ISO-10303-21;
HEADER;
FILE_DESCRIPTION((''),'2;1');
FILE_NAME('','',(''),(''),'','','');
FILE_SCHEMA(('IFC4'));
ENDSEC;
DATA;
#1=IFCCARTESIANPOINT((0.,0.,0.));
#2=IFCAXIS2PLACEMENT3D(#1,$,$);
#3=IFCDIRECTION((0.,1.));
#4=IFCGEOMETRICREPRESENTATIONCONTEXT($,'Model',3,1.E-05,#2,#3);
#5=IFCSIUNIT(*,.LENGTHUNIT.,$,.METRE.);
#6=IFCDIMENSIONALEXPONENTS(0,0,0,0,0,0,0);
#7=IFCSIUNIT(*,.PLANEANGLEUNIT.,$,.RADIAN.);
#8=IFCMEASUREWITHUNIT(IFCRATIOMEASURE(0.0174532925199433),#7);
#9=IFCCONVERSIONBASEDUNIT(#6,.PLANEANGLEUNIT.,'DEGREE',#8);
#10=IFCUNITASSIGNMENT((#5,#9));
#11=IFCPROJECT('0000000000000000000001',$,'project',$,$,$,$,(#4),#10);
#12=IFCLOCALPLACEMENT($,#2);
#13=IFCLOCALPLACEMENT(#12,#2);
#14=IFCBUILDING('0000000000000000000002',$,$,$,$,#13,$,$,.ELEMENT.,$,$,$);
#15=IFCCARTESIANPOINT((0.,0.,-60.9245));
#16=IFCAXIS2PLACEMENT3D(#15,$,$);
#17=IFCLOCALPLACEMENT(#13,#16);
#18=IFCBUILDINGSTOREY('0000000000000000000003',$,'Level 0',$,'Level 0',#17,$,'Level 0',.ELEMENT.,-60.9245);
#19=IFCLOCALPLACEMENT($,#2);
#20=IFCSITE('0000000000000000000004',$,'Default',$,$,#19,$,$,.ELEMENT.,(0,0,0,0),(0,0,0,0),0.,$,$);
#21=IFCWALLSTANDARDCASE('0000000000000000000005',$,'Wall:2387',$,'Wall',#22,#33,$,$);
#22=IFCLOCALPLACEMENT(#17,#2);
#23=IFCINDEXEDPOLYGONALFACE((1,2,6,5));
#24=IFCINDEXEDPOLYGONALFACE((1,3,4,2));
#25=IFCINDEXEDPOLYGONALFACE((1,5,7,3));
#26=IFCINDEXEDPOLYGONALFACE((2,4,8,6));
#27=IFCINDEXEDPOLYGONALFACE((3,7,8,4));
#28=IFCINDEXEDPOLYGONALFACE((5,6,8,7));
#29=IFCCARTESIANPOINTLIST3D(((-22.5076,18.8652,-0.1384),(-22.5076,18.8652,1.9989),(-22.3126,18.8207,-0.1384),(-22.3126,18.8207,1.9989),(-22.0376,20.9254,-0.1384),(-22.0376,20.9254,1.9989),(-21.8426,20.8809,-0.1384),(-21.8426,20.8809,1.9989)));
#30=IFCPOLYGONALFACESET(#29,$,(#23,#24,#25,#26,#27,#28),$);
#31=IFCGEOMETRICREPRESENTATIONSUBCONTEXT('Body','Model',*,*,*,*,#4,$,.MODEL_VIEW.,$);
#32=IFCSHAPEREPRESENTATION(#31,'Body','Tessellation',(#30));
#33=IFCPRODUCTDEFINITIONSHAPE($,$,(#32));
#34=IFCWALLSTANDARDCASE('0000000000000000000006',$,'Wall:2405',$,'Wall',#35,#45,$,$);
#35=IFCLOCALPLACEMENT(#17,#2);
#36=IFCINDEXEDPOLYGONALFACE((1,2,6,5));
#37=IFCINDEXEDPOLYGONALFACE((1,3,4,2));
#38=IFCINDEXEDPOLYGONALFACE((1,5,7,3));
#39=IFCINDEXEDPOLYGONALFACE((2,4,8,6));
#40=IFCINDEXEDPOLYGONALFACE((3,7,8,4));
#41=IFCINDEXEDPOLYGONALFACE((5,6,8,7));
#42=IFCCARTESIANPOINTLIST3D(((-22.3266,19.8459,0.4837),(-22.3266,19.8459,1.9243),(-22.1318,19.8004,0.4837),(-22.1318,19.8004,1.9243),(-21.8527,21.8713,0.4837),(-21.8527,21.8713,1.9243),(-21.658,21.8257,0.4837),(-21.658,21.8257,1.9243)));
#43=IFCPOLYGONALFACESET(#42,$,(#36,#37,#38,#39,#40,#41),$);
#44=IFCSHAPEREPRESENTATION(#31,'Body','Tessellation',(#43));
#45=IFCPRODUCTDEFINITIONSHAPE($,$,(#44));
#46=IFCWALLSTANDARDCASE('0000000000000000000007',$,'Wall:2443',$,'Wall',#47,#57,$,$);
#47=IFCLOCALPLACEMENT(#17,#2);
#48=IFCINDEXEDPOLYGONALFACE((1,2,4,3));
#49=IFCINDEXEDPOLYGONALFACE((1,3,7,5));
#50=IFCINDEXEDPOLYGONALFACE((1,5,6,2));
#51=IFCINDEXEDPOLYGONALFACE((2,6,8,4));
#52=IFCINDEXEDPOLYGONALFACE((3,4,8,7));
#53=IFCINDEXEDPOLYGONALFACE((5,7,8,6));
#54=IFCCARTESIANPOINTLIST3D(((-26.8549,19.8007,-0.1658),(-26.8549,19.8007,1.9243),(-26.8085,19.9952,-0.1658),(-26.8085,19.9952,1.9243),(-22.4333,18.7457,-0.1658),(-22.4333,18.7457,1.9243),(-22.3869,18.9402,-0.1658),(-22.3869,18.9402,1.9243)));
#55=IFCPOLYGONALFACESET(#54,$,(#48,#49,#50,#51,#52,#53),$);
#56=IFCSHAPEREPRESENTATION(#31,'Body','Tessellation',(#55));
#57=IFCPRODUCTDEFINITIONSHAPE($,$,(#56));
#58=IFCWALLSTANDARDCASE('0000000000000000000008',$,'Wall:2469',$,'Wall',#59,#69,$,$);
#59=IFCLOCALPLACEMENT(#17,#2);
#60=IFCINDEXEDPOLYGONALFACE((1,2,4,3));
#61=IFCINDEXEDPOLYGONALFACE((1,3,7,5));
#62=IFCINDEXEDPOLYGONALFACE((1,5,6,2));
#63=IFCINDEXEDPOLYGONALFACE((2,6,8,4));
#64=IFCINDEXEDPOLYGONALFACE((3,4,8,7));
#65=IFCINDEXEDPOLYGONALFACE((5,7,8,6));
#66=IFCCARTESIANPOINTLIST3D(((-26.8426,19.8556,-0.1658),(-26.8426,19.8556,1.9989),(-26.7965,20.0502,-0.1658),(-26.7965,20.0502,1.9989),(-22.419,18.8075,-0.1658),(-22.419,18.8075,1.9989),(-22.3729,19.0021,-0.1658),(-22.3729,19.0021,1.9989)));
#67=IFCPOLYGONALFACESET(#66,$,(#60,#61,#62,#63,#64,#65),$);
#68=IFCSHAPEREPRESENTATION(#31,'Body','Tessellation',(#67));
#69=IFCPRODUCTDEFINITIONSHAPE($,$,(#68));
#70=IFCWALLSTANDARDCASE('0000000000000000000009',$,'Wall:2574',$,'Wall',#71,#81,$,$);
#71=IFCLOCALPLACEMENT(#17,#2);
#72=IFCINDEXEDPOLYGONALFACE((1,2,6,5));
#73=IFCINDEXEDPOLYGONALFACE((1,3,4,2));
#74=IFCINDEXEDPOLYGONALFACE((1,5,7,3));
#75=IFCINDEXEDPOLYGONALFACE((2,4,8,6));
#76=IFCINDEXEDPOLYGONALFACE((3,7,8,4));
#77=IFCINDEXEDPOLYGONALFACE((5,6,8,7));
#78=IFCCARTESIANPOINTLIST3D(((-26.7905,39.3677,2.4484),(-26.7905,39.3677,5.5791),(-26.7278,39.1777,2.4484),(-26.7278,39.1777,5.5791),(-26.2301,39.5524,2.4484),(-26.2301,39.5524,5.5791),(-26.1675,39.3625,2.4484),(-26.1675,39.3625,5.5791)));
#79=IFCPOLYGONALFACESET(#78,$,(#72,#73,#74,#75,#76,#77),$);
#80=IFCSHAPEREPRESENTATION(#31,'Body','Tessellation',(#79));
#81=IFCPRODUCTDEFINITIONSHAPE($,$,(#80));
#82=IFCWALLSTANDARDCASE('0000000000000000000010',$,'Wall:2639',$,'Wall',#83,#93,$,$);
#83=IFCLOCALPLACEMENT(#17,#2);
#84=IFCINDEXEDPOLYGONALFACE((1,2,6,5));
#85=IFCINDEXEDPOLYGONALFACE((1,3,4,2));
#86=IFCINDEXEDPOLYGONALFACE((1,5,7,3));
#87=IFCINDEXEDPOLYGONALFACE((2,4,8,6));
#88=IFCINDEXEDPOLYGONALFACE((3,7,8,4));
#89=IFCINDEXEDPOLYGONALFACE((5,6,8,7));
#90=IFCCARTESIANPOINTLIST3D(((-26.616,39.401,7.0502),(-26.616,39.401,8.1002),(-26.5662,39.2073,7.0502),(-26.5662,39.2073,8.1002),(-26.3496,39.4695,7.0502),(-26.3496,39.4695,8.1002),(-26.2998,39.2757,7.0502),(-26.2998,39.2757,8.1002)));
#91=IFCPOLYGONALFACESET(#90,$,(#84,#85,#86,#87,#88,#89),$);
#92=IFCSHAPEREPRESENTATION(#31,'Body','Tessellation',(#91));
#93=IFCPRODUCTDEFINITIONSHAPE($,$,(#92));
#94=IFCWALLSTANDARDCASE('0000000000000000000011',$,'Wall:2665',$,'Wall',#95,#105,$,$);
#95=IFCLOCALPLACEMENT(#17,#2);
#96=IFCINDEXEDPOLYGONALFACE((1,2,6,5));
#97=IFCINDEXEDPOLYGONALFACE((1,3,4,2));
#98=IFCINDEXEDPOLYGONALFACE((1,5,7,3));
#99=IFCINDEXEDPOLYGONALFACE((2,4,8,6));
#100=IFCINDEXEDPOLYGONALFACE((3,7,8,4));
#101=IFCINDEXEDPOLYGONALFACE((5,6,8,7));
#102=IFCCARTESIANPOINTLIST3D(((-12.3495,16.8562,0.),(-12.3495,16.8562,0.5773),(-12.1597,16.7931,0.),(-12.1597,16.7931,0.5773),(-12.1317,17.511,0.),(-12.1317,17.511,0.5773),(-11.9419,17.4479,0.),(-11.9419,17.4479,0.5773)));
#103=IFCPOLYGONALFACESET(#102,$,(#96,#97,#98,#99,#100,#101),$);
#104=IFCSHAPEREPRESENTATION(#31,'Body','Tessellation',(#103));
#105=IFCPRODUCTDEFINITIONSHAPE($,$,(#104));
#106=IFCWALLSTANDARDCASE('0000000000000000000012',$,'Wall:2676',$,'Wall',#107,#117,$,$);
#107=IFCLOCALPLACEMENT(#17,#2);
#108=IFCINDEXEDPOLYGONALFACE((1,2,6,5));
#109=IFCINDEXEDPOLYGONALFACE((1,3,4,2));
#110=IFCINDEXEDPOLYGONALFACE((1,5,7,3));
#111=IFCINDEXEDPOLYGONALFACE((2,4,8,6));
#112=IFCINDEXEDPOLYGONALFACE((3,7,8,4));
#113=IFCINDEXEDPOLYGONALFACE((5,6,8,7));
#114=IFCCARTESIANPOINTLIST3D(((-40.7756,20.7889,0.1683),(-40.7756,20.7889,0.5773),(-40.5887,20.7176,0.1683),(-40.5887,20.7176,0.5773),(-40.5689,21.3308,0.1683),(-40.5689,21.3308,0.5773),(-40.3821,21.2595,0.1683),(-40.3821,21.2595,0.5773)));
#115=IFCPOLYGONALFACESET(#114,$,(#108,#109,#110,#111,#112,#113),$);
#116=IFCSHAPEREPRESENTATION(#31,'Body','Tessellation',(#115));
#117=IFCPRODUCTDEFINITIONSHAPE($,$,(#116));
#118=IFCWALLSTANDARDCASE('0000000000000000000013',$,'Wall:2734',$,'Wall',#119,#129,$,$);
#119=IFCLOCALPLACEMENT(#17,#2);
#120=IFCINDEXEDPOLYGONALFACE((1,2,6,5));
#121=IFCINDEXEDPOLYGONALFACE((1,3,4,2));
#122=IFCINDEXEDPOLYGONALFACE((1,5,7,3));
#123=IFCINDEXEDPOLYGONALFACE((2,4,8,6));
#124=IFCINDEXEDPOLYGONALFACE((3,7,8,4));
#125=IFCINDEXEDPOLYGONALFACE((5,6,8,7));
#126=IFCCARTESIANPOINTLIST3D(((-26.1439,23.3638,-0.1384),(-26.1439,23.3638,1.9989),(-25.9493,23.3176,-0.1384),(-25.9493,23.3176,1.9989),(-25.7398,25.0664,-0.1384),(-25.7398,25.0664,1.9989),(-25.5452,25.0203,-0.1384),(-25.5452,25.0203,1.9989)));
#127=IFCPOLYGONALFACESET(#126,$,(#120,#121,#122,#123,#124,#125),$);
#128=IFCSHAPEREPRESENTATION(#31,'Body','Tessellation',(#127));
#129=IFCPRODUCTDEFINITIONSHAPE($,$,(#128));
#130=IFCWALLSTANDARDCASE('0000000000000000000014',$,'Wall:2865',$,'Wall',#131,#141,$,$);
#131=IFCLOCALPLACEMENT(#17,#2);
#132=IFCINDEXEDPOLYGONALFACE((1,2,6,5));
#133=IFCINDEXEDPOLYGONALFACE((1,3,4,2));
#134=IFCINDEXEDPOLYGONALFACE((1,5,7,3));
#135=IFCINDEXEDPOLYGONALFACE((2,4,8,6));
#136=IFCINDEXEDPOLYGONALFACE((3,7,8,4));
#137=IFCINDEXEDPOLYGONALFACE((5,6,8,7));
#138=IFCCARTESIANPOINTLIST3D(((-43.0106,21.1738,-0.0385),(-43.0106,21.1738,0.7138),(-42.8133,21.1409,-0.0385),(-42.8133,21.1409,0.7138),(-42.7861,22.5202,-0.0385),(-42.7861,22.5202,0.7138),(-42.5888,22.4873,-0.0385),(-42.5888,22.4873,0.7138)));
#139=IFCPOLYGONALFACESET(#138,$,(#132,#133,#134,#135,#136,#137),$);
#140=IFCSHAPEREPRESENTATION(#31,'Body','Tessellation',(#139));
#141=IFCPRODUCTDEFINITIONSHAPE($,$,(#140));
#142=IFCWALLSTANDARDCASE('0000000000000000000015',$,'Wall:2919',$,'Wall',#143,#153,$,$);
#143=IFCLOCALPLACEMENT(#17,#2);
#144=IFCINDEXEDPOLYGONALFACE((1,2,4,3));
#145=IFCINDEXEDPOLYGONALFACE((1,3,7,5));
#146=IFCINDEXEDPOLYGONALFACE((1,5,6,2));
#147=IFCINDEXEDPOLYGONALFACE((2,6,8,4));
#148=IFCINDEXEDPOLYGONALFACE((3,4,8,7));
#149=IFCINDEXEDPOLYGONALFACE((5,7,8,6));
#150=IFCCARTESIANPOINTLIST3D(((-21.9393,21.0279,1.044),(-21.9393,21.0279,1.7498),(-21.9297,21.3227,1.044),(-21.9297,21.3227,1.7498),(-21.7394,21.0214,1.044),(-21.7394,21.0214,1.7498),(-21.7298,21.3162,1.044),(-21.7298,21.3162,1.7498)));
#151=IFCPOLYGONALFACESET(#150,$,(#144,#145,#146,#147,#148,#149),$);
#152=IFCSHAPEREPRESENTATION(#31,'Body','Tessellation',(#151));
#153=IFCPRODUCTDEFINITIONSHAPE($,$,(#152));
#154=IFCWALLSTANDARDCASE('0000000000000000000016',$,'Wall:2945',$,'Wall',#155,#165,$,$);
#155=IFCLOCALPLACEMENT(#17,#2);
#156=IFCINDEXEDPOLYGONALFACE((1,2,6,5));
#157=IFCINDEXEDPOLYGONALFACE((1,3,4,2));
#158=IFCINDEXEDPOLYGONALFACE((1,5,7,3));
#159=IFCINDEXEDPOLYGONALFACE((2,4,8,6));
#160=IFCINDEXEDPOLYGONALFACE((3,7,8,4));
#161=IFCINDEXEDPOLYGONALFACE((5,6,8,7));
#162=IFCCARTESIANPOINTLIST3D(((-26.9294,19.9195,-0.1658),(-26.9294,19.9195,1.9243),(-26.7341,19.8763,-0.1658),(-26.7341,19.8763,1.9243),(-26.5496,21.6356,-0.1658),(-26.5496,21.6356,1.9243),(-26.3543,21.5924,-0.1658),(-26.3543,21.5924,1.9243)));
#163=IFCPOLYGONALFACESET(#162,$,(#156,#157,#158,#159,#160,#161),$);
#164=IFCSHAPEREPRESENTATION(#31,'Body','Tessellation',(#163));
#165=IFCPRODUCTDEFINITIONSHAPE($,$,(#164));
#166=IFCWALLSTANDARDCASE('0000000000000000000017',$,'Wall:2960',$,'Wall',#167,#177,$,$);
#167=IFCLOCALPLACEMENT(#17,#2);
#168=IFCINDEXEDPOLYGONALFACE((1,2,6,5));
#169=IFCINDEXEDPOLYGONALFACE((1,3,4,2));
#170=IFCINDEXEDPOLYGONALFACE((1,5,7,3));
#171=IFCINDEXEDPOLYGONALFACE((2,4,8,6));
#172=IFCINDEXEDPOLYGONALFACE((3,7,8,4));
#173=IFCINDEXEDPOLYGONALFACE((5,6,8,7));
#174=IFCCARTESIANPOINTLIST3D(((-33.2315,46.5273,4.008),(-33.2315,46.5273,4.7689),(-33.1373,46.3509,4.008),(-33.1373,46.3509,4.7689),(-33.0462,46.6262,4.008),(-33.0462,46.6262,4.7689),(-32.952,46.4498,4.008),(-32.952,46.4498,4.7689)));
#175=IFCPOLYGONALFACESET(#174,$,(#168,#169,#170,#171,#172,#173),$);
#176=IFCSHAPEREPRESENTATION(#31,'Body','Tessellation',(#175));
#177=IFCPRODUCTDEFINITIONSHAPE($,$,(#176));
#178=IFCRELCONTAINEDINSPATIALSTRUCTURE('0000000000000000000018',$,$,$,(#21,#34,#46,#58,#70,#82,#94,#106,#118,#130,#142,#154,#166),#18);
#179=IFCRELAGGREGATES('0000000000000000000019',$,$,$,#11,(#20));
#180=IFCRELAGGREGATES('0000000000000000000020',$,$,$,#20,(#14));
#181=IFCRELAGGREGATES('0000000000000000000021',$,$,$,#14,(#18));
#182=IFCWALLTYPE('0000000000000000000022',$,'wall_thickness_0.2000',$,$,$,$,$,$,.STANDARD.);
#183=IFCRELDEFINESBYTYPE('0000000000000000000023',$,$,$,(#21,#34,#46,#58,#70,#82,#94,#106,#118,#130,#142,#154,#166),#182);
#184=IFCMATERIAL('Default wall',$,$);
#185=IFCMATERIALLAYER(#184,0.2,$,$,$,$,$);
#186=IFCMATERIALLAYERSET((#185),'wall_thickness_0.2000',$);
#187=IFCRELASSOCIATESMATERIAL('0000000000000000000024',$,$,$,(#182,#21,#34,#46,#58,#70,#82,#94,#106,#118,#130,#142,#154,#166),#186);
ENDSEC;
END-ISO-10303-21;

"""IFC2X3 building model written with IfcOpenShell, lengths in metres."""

from ifc_helpers import new_model, entity, si_unit, converted_unit, direction, frame, origin, place, context, subcontext, project, spatial, polyline, outline, extrude, material, layer, layer_set, layer_usage, type_object, element, save


model = new_model("IFC2X3")

# Units and contexts
model_context = context("Model", 3, precision=1e-05, world=origin(), true_north=direction((0.0, 1.0)))
body_context = subcontext(model_context, "Body", "Model", "MODEL_VIEW")
ifc_project = project(units=[si_unit("LENGTHUNIT", "METRE"), converted_unit("PLANEANGLEUNIT", "DEGREE", entity("IfcRatioMeasure", 0.0174532925199433), si_unit("PLANEANGLEUNIT", "RADIAN"), dimensions=[0, 0, 0, 0, 0, 0, 0])], contexts=[model_context])

# Site, building, storey
site_placement = place(None, origin())
site = spatial("IfcSite", under=ifc_project, at=site_placement, Name="Default", CompositionType="ELEMENT", RefLatitude=(0, 0, 0, 0), RefLongitude=(0, 0, 0, 0), RefElevation=0.0)
placement_1 = place(None, origin())
building_placement = place(placement_1, origin())
building = spatial("IfcBuilding", under=site, at=building_placement, CompositionType="ELEMENT")
storey_placement = place(building_placement, frame((0.0, 0.0, -60.9245)))
storey = spatial("IfcBuildingStorey", under=building, at=storey_placement, Name="Level 0", ObjectType="Level 0", LongName="Level 0", CompositionType="ELEMENT", Elevation=-60.9245)

# Walls
ifc_material = material(Name="Default wall")
ifc_layer = layer(ifc_material, 0.2)
ifc_layer_set = layer_set([ifc_layer], Name="wall_thickness_0.2000")
ifc_layer_usage = layer_usage(ifc_layer_set, "AXIS2", "POSITIVE", -0.1)
wall_type = type_object("IfcWallType", Name="wall_thickness_0.2000", PredefinedType="STANDARD", material=ifc_layer_set)
placement_2 = place(building_placement, frame((0.0, 0.0, -61.0629)))
wall_1_placement = place(placement_2, frame((-21.9401, 20.9032, 0.0), z_axis=(0.0, 0.0, 1.0), x_axis=(-0.222418, -0.974951, 0.0)))
element("IfcWallStandardCase", 1, at=wall_1_placement, inside=storey, type_object=wall_type, material=ifc_layer_usage, Name="Wall:2387", ObjectType="Wall", context=body_context, shape_type="SweptSolid", body=[
    extrude(outline(polyline([(2.1132, -0.1), (2.1132, 0.1), (0.0, 0.1), (0.0, -0.1), (2.1132, -0.1)])), origin(), (0.0, 0.0, 1.0), 2.1372),
])
placement_3 = place(building_placement, frame((0.0, 0.0, -60.4408)))
wall_2_placement = place(placement_3, frame((-21.7553, 21.8485, 0.0), z_axis=(0.0, 0.0, 1.0), x_axis=(-0.227822, -0.973703, 0.0)))
element("IfcWallStandardCase", 2, at=wall_2_placement, inside=storey, type_object=wall_type, material=ifc_layer_usage, Name="Wall:2405", ObjectType="Wall", context=body_context, shape_type="SweptSolid", body=[
    extrude(outline(polyline([(2.08, -0.1), (2.08, 0.1), (0.0, 0.1), (0.0, -0.1), (2.08, -0.1)])), origin(), (0.0, 0.0, 1.0), 1.4406),
])
placement_4 = place(building_placement, frame((0.0, 0.0, -61.0903)))
wall_3_placement = place(placement_4, frame((-26.8317, 19.8979, 0.0), z_axis=(0.0, 0.0, 1.0), x_axis=(0.972696, -0.232084, 0.0)))
element("IfcWallStandardCase", 3, at=wall_3_placement, inside=storey, type_object=wall_type, material=ifc_layer_usage, Name="Wall:2443", ObjectType="Wall", context=body_context, shape_type="SweptSolid", body=[
    extrude(outline(polyline([(4.5458, -0.1), (4.5458, 0.1), (0.0, 0.1), (0.0, -0.1), (4.5458, -0.1)])), origin(), (0.0, 0.0, 1.0), 2.0901),
])
placement_5 = place(building_placement, frame((0.0, 0.0, -61.0903)))
wall_4_placement = place(placement_5, frame((-26.8196, 19.9529, 0.0), z_axis=(0.0, 0.0, 1.0), x_axis=(0.97306, -0.230553, 0.0)))
element("IfcWallStandardCase", 4, at=wall_4_placement, inside=storey, type_object=wall_type, material=ifc_layer_usage, Name="Wall:2469", ObjectType="Wall", context=body_context, shape_type="SweptSolid", body=[
    extrude(outline(polyline([(4.5461, -0.1), (4.5461, 0.1), (0.0, 0.1), (0.0, -0.1), (4.5461, -0.1)])), origin(), (0.0, 0.0, 1.0), 2.1647),
])
placement_6 = place(building_placement, frame((0.0, 0.0, -58.4761)))
wall_5_placement = place(placement_6, frame((-26.1988, 39.4575, 0.0), z_axis=(0.0, 0.0, 1.0), x_axis=(-0.94969, -0.313193, 0.0)))
element("IfcWallStandardCase", 5, at=wall_5_placement, inside=storey, type_object=wall_type, material=ifc_layer_usage, Name="Wall:2574", ObjectType="Wall", context=body_context, shape_type="SweptSolid", body=[
    extrude(outline(polyline([(0.59, -0.1), (0.59, 0.1), (0.0, 0.1), (0.0, -0.1), (0.59, -0.1)])), origin(), (0.0, 0.0, 1.0), 3.1307),
])
placement_7 = place(building_placement, frame((0.0, 0.0, -53.8743)))
wall_6_placement = place(placement_7, frame((-26.3247, 39.3726, 0.0), z_axis=(0.0, 0.0, 1.0), x_axis=(-0.968547, -0.24883, 0.0)))
element("IfcWallStandardCase", 6, at=wall_6_placement, inside=storey, type_object=wall_type, material=ifc_layer_usage, Name="Wall:2639", ObjectType="Wall", context=body_context, shape_type="SweptSolid", body=[
    extrude(outline(polyline([(0.275, -0.1), (0.275, 0.1), (0.0, 0.1), (0.0, -0.1), (0.275, -0.1)])), origin(), (0.0, 0.0, 1.0), 1.05),
])
wall_7_placement = place(storey_placement, frame((-12.2546, 16.8247, 0.0), z_axis=(0.0, 0.0, 1.0), x_axis=(0.315593, 0.948895, 0.0)))
element("IfcWallStandardCase", 7, at=wall_7_placement, inside=storey, type_object=wall_type, material=ifc_layer_usage, Name="Wall:2665", ObjectType="Wall", context=body_context, shape_type="SweptSolid", body=[
    extrude(outline(polyline([(0.69, -0.1), (0.69, 0.1), (0.0, 0.1), (0.0, -0.1), (0.69, -0.1)])), origin(), (0.0, 0.0, 1.0), 0.5773),
])
placement_8 = place(building_placement, frame((0.0, 0.0, -60.7562)))
wall_8_placement = place(placement_8, frame((-40.6822, 20.7532, 0.0), z_axis=(0.0, 0.0, 1.0), x_axis=(0.356318, 0.934365, 0.0)))
element("IfcWallStandardCase", 8, at=wall_8_placement, inside=storey, type_object=wall_type, material=ifc_layer_usage, Name="Wall:2676", ObjectType="Wall", context=body_context, shape_type="SweptSolid", body=[
    extrude(outline(polyline([(0.58, -0.1), (0.58, 0.1), (0.0, 0.1), (0.0, -0.1), (0.58, -0.1)])), origin(), (0.0, 0.0, 1.0), 0.4089),
])
placement_9 = place(building_placement, frame((0.0, 0.0, -61.0629)))
wall_9_placement = place(placement_9, frame((-25.6425, 25.0433, 0.0), z_axis=(0.0, 0.0, 1.0), x_axis=(-0.230955, -0.972964, 0.0)))
element("IfcWallStandardCase", 9, at=wall_9_placement, inside=storey, type_object=wall_type, material=ifc_layer_usage, Name="Wall:2734", ObjectType="Wall", context=body_context, shape_type="SweptSolid", body=[
    extrude(outline(polyline([(1.75, -0.1), (1.75, 0.1), (0.0, 0.1), (0.0, -0.1), (1.75, -0.1)])), origin(), (0.0, 0.0, 1.0), 2.1372),
])
placement_10 = place(building_placement, frame((0.0, 0.0, -60.963)))
wall_10_placement = place(placement_10, frame((-42.912, 21.1573, 0.0), z_axis=(0.0, 0.0, 1.0), x_axis=(0.164471, 0.986382, 0.0)))
element("IfcWallStandardCase", 10, at=wall_10_placement, inside=storey, type_object=wall_type, material=ifc_layer_usage, Name="Wall:2865", ObjectType="Wall", context=body_context, shape_type="SweptSolid", body=[
    extrude(outline(polyline([(1.365, -0.1), (1.365, 0.1), (0.0, 0.1), (0.0, -0.1), (1.365, -0.1)])), origin(), (0.0, 0.0, 1.0), 0.7523),
])
placement_11 = place(building_placement, frame((0.0, 0.0, -59.8805)))
wall_11_placement = place(placement_11, frame((-21.8393, 21.0247, 0.0), z_axis=(0.0, 0.0, 1.0), x_axis=(0.032528, 0.999471, 0.0)))
element("IfcWallStandardCase", 11, at=wall_11_placement, inside=storey, type_object=wall_type, material=ifc_layer_usage, Name="Wall:2919", ObjectType="Wall", context=body_context, shape_type="SweptSolid", body=[
    extrude(outline(polyline([(0.295, -0.1), (0.295, 0.1), (0.0, 0.1), (0.0, -0.1), (0.295, -0.1)])), origin(), (0.0, 0.0, 1.0), 0.7057),
])
placement_12 = place(building_placement, frame((0.0, 0.0, -61.0903)))
wall_12_placement = place(placement_12, frame((-26.452, 21.614, 0.0), z_axis=(0.0, 0.0, 1.0), x_axis=(-0.216058, -0.976381, 0.0)))
element("IfcWallStandardCase", 12, at=wall_12_placement, inside=storey, type_object=wall_type, material=ifc_layer_usage, Name="Wall:2945", ObjectType="Wall", context=body_context, shape_type="SweptSolid", body=[
    extrude(outline(polyline([(1.7576, -0.1), (1.7576, 0.1), (0.0, 0.1), (0.0, -0.1), (1.7576, -0.1)])), origin(), (0.0, 0.0, 1.0), 2.0901),
])
placement_13 = place(building_placement, frame((0.0, 0.0, -56.9165)))
wall_13_placement = place(placement_13, frame((-32.9991, 46.538, 0.0), z_axis=(0.0, 0.0, 1.0), x_axis=(-0.882147, -0.470974, 0.0)))
element("IfcWallStandardCase", 13, at=wall_13_placement, inside=storey, type_object=wall_type, material=ifc_layer_usage, Name="Wall:2960", ObjectType="Wall", context=body_context, shape_type="SweptSolid", body=[
    extrude(outline(polyline([(0.21, -0.1), (0.21, 0.1), (0.0, 0.1), (0.0, -0.1), (0.21, -0.1)])), origin(), (0.0, 0.0, 1.0), 0.7609),
])

save(model, "model.ifc")
